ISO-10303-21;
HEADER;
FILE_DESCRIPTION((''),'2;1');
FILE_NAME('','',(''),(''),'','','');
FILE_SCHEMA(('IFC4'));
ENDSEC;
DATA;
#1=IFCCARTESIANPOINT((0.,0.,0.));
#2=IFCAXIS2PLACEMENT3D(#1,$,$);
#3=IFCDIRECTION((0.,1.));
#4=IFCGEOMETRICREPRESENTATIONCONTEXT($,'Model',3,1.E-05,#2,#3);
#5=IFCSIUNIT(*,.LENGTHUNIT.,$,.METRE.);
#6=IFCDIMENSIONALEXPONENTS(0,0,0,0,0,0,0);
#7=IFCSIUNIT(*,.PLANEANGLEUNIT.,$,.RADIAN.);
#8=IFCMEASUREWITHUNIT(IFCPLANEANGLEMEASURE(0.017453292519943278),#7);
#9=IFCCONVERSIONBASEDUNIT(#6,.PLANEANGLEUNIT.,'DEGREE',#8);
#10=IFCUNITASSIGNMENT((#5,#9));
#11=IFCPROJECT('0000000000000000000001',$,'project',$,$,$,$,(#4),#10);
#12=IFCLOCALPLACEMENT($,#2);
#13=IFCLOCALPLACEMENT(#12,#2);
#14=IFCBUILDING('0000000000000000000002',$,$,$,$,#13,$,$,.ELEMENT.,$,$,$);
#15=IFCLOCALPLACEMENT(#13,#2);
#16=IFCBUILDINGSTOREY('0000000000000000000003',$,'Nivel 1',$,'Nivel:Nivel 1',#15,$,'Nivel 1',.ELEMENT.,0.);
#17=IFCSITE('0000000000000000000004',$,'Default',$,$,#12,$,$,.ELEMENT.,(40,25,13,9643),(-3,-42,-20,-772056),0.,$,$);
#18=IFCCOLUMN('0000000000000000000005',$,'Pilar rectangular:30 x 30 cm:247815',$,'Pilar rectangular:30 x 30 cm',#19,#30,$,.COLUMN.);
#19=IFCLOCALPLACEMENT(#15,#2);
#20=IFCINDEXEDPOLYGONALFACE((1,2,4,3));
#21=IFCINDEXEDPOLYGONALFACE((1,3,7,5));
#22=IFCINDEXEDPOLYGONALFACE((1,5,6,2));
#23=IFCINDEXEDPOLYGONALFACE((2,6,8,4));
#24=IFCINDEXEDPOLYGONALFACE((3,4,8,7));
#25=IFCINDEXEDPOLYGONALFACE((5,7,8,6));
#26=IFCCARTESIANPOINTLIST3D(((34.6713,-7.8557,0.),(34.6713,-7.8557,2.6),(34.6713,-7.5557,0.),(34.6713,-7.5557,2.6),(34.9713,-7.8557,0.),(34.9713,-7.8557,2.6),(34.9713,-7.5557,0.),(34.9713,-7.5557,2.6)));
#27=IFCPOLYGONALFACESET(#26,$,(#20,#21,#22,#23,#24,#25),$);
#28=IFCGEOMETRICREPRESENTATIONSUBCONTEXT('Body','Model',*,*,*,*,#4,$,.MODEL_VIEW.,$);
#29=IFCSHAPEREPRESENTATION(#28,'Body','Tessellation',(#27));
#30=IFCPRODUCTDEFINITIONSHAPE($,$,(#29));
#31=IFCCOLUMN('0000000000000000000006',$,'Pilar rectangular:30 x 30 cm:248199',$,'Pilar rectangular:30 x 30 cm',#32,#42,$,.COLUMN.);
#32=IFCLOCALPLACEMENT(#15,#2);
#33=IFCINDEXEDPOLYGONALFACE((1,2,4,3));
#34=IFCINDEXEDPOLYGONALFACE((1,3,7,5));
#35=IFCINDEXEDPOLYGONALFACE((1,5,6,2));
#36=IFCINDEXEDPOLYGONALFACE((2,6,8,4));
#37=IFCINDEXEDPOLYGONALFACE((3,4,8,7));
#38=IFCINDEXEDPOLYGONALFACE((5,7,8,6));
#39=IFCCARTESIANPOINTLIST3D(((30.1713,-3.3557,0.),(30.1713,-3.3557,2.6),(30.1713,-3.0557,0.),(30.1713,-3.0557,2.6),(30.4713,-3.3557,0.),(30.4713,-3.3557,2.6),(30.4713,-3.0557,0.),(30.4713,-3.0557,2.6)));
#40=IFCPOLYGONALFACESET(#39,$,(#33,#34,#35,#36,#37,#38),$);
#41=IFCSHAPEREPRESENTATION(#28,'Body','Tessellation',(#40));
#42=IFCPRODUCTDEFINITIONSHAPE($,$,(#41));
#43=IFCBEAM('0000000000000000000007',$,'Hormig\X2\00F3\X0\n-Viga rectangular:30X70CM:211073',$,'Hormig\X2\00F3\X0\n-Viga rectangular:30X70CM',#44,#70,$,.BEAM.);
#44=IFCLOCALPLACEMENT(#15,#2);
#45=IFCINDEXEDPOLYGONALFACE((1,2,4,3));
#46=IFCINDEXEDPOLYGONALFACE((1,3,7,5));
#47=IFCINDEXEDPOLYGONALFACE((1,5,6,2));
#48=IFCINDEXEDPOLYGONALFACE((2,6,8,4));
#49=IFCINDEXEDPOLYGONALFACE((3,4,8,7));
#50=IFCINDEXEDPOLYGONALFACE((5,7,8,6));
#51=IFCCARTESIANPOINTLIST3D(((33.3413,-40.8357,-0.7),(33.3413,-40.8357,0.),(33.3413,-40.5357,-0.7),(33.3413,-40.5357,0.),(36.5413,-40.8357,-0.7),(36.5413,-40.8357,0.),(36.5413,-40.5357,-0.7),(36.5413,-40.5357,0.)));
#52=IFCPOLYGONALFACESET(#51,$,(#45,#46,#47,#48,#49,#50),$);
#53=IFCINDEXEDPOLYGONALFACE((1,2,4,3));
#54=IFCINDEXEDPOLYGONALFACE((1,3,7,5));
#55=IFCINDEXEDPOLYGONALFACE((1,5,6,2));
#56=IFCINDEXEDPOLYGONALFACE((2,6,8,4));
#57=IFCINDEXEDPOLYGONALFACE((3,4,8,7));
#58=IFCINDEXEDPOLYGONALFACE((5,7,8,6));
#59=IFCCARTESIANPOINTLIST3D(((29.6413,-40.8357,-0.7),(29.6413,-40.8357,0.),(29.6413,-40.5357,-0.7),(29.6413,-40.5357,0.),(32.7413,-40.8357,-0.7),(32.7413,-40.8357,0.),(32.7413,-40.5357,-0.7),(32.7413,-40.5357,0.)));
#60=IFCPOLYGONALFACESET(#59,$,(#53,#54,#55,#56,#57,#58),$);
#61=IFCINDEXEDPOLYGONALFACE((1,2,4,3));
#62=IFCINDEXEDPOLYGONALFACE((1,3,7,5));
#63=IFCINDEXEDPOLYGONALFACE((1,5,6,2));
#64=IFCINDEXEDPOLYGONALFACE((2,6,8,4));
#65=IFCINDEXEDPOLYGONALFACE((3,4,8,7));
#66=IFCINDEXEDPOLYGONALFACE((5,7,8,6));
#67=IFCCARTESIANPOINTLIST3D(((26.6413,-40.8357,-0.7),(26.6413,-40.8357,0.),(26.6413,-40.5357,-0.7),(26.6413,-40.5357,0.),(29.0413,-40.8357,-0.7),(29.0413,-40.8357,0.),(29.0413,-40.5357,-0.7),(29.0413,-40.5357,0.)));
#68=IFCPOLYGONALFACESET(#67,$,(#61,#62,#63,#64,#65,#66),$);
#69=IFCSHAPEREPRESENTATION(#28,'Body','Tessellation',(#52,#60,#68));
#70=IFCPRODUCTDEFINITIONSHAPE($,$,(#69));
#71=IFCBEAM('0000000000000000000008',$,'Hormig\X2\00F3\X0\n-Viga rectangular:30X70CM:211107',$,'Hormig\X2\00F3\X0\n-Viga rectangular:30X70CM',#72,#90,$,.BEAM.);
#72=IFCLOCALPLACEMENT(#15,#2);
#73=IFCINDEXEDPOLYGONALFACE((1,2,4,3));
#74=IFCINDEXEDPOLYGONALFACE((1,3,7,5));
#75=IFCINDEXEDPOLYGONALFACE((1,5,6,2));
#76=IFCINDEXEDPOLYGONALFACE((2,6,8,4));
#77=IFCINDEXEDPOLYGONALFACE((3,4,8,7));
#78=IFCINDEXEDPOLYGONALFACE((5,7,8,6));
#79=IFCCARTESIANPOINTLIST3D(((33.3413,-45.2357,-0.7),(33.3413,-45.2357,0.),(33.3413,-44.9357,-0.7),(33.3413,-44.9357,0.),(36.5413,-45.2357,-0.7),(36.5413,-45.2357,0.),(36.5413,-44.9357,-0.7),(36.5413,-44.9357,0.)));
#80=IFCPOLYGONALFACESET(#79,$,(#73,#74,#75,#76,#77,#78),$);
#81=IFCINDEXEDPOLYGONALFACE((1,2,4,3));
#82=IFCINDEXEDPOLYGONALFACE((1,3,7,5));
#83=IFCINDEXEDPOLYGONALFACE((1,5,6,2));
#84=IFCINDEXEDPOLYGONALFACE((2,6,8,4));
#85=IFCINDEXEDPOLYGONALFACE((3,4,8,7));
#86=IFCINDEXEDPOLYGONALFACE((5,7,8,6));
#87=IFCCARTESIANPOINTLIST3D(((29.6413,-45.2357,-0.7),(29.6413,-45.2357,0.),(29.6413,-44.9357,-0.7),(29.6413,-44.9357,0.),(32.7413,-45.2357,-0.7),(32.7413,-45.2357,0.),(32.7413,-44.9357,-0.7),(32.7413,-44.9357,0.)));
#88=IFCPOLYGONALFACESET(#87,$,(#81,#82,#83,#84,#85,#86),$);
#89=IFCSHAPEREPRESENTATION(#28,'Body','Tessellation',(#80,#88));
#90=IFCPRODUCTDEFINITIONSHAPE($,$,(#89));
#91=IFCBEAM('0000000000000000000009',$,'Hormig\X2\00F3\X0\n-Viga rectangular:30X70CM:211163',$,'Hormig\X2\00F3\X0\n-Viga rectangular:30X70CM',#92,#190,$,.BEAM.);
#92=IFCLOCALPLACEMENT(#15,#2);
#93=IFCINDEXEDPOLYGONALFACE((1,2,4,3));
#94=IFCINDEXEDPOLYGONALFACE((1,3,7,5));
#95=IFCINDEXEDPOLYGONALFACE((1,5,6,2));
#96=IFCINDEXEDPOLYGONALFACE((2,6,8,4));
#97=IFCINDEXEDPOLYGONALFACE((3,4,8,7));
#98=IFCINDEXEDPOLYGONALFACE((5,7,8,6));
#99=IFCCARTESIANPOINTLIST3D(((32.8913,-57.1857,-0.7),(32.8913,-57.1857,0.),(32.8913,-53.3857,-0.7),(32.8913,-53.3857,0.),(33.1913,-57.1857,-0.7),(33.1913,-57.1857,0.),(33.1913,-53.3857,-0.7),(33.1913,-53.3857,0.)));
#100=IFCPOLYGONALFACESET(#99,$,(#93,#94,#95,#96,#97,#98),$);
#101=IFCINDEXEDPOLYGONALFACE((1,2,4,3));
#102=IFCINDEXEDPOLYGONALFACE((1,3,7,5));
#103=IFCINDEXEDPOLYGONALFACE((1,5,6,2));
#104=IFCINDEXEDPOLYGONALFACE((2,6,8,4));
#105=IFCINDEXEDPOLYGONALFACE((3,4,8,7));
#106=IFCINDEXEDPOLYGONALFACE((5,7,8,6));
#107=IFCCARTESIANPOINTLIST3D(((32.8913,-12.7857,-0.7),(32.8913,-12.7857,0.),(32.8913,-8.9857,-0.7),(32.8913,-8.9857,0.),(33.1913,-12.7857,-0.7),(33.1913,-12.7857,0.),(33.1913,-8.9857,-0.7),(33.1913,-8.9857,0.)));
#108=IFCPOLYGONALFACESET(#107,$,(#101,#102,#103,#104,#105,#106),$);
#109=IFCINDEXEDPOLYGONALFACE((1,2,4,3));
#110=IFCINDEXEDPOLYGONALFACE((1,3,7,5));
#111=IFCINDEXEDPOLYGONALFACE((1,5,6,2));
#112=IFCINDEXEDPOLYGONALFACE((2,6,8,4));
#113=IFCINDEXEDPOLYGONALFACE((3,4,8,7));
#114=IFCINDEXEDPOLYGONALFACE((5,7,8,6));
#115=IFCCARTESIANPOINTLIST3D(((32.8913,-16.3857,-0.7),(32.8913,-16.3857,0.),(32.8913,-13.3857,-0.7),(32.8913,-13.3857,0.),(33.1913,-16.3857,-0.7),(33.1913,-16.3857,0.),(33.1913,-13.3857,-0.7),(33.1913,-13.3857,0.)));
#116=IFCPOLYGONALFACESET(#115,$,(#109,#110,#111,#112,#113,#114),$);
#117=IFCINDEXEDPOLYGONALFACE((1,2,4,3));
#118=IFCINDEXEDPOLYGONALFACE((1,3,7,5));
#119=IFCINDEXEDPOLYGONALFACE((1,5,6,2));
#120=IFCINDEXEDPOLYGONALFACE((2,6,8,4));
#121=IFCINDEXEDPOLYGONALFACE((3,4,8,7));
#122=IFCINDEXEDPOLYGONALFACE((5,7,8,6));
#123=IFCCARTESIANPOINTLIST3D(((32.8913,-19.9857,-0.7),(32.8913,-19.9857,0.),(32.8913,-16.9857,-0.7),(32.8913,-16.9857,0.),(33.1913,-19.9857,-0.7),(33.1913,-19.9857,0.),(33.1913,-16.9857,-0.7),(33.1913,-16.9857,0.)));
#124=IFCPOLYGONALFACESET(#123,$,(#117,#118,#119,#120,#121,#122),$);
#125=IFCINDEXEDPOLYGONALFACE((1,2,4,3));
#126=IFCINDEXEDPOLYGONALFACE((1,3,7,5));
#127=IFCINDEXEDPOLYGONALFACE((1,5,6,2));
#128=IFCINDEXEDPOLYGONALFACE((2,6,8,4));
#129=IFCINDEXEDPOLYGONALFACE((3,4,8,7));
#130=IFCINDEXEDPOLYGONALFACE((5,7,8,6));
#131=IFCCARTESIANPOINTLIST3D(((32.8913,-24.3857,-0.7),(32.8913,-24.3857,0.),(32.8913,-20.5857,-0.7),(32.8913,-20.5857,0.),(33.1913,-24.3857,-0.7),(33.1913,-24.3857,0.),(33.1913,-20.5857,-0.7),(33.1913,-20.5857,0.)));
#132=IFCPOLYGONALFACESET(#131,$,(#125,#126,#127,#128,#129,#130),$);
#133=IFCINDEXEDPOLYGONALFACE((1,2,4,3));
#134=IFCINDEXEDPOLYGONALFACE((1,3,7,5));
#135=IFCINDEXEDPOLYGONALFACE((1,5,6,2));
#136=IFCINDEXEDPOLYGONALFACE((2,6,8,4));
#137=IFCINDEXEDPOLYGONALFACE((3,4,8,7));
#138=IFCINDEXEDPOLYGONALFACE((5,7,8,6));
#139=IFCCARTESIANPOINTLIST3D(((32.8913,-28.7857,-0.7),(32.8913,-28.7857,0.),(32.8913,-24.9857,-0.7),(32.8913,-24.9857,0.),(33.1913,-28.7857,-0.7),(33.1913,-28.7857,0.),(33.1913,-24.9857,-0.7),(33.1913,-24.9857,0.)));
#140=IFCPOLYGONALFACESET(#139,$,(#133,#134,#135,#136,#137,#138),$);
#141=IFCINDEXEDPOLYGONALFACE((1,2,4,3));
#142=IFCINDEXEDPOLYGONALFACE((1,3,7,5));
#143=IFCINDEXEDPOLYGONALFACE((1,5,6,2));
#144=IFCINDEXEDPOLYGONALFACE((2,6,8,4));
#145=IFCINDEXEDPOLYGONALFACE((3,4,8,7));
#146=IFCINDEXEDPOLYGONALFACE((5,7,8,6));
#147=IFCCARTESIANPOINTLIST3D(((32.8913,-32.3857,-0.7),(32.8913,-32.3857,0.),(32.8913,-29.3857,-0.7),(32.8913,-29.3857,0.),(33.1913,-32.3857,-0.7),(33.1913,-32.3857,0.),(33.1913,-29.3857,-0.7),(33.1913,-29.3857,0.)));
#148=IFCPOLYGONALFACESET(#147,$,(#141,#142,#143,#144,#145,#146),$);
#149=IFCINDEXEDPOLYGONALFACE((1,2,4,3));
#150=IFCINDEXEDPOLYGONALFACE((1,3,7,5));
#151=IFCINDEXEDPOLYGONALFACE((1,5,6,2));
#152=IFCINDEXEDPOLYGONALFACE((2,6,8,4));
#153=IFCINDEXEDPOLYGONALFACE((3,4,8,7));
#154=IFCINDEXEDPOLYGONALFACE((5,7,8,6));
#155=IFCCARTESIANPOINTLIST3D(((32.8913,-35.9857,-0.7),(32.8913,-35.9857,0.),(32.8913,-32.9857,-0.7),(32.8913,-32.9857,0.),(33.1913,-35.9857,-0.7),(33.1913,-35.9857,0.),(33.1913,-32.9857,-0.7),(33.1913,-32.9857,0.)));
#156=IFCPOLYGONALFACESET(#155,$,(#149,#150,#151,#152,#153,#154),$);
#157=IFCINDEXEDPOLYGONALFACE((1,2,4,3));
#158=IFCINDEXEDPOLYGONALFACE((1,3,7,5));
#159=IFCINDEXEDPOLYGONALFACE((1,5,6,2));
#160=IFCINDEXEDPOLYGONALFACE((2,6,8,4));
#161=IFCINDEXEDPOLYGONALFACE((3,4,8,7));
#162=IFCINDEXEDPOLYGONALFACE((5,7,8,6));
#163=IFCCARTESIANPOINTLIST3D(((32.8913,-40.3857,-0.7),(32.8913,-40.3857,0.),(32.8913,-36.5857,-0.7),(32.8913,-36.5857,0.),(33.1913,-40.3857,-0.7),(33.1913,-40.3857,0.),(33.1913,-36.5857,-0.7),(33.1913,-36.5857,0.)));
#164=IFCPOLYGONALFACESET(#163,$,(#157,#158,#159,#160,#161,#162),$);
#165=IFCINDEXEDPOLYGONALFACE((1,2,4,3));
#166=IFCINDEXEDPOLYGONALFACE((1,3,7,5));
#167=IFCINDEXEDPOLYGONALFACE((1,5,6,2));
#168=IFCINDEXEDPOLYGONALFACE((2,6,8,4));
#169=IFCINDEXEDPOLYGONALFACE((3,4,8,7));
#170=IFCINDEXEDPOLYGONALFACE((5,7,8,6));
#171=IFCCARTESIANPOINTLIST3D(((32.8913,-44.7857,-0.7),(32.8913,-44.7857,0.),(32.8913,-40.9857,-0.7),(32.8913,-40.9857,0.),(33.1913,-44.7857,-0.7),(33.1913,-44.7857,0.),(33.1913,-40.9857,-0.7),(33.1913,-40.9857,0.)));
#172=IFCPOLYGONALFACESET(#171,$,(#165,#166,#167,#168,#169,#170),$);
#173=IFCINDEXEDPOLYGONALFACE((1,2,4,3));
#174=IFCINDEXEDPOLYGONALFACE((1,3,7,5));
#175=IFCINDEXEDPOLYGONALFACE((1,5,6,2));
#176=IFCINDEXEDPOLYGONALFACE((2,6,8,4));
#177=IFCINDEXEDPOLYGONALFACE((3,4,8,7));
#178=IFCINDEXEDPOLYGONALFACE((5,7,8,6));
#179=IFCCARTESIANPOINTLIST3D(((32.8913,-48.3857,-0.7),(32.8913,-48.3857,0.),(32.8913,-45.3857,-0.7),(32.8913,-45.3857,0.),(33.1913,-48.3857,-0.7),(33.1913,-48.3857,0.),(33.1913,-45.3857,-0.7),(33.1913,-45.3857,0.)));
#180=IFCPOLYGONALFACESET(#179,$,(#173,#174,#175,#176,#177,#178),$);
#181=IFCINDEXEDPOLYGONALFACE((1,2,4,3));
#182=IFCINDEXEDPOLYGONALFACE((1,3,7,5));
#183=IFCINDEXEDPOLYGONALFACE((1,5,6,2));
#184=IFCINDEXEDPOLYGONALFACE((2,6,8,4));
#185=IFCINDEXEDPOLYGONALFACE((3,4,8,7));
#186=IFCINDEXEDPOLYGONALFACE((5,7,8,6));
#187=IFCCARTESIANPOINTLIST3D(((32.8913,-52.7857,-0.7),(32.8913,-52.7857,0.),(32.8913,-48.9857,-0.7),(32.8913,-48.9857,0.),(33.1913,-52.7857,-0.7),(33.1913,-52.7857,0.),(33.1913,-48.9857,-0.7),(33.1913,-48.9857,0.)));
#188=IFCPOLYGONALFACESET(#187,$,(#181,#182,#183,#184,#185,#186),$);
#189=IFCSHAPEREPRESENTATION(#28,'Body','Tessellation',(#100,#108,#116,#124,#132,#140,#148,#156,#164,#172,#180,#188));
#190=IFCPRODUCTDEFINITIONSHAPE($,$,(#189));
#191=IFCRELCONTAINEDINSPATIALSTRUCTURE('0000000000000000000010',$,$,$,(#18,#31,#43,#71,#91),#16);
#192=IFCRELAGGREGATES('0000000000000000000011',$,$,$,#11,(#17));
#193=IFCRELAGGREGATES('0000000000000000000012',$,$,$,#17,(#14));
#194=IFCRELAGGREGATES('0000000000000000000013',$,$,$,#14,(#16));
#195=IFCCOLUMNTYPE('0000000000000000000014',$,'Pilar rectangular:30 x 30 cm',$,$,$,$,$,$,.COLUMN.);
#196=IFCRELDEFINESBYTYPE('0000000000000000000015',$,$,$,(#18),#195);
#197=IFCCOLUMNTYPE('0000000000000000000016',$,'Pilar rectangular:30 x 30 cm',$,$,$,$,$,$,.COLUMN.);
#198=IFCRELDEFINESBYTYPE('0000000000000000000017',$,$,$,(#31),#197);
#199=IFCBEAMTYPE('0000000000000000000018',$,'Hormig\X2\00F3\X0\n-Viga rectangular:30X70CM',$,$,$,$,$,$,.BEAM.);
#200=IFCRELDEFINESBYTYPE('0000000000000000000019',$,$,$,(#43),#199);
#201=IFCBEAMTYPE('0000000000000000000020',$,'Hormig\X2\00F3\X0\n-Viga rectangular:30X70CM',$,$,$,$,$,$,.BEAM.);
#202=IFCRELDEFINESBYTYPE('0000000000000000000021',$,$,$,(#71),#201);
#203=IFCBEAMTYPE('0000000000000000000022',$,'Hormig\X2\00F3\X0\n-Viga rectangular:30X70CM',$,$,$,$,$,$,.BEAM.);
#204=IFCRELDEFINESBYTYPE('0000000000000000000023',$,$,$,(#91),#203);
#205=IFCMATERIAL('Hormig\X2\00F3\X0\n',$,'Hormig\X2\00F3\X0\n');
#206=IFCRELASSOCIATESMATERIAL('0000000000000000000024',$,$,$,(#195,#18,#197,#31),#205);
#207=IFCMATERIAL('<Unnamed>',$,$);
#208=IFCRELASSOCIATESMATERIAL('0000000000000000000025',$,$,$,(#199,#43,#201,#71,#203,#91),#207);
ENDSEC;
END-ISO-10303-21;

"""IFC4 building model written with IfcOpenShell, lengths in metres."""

from ifc_helpers import new_model, entity, si_unit, converted_unit, direction, frame, origin, place, context, subcontext, project, spatial, indexed_curve, outline, extrude, source, transform, mapped, material, type_object, type_shapes, element, save


model = new_model("IFC4")

# Units and contexts
model_context = context("Model", 3, precision=1e-05, world=origin(), true_north=direction((0.0, 1.0)))
body_context = subcontext(model_context, "Body", "Model", "MODEL_VIEW")
ifc_project = project(units=[si_unit("LENGTHUNIT", "METRE"), converted_unit("PLANEANGLEUNIT", "DEGREE", entity("IfcPlaneAngleMeasure", 0.017453292519943278), si_unit("PLANEANGLEUNIT", "RADIAN"), dimensions=[0, 0, 0, 0, 0, 0, 0])], contexts=[model_context])

# Site, building, storey
site_placement = place(None, origin())
site = spatial("IfcSite", under=ifc_project, at=site_placement, Name="Default", CompositionType="ELEMENT", RefLatitude=(40, 25, 13, 9643), RefLongitude=(-3, -42, -20, -772056), RefElevation=0.0)
building_placement = place(site_placement, origin())
building = spatial("IfcBuilding", under=site, at=building_placement, CompositionType="ELEMENT")
storey_placement = place(building_placement, origin())
storey = spatial("IfcBuildingStorey", under=building, at=storey_placement, Name="Nivel 1", ObjectType="Nivel:Nivel 1", LongName="Nivel 1", CompositionType="ELEMENT", Elevation=0.0)

# Columns
ifc_material_1 = material(Name="Hormigón", Category="Hormigón")
column_type_1 = type_object("IfcColumnType", Name="Pilar rectangular:30 x 30 cm", PredefinedType="COLUMN", material=ifc_material_1)
shared_shape_1 = source(origin(), body_context, "Body", "SweptSolid", [
    extrude(outline(indexed_curve([(-0.15, -0.15), (0.15, -0.15), (0.15, 0.15), (-0.15, 0.15), (-0.15, -0.15)], self_intersect=False)), frame((34.8213, -7.7057, 0.0), z_axis=(0.0, 0.0, 1.0), x_axis=(-1.0, 0.0, 0.0)), (0.0, 0.0, 1.0), 2.6),
])
type_shapes(column_type_1, [shared_shape_1])
column_1_placement = place(storey_placement, origin())
element("IfcColumn", 1, at=column_1_placement, inside=storey, type_object=column_type_1, material=ifc_material_1, Name="Pilar rectangular:30 x 30 cm:247815", ObjectType="Pilar rectangular:30 x 30 cm", PredefinedType="COLUMN", context=body_context, shape_type="MappedRepresentation", body=[
    mapped(shared_shape_1, transform((0.0, 0.0, 0.0), scale=1.0)),
])
column_type_2 = type_object("IfcColumnType", Name="Pilar rectangular:30 x 30 cm", PredefinedType="COLUMN", material=ifc_material_1)
shared_shape_2 = source(origin(), body_context, "Body", "SweptSolid", [
    extrude(outline(indexed_curve([(-0.15, -0.15), (0.15, -0.15), (0.15, 0.15), (-0.15, 0.15), (-0.15, -0.15)], self_intersect=False)), frame((30.3213, -3.2057, 0.0), z_axis=(0.0, 0.0, 1.0), x_axis=(-1.0, 0.0, 0.0)), (0.0, 0.0, 1.0), 2.6),
])
type_shapes(column_type_2, [shared_shape_2])
column_2_placement = place(storey_placement, origin())
element("IfcColumn", 2, at=column_2_placement, inside=storey, type_object=column_type_2, material=ifc_material_1, Name="Pilar rectangular:30 x 30 cm:248199", ObjectType="Pilar rectangular:30 x 30 cm", PredefinedType="COLUMN", context=body_context, shape_type="MappedRepresentation", body=[
    mapped(shared_shape_2, transform((0.0, 0.0, 0.0), scale=1.0)),
])

# Beams
ifc_material_2 = material(Name="<Unnamed>")
beam_type_1 = type_object("IfcBeamType", Name="Hormigón-Viga rectangular:30X70CM", PredefinedType="BEAM", material=ifc_material_2)
shared_shape_3 = source(origin(), body_context, "Body", "SweptSolid", [
    extrude(outline(indexed_curve([(-0.35, -0.15), (0.35, -0.15), (0.35, 0.15), (-0.35, 0.15), (-0.35, -0.15)], self_intersect=False)), frame((36.5413, -40.6857, -0.35), z_axis=(-1.0, 0.0, 0.0), x_axis=(0.0, 0.0, -1.0)), (0.0, 0.0, 1.0), 3.2),
    extrude(outline(indexed_curve([(-0.35, -0.15), (0.35, -0.15), (0.35, 0.15), (-0.35, 0.15), (-0.35, -0.15)], self_intersect=False)), frame((32.7413, -40.6857, -0.35), z_axis=(-1.0, 0.0, 0.0), x_axis=(0.0, 0.0, -1.0)), (0.0, 0.0, 1.0), 3.1),
    extrude(outline(indexed_curve([(-0.35, -0.15), (0.35, -0.15), (0.35, 0.15), (-0.35, 0.15), (-0.35, -0.15)], self_intersect=False)), frame((29.0413, -40.6857, -0.35), z_axis=(-1.0, 0.0, 0.0), x_axis=(0.0, 0.0, -1.0)), (0.0, 0.0, 1.0), 2.4),
])
type_shapes(beam_type_1, [shared_shape_3])
beam_1_placement = place(storey_placement, origin())
element("IfcBeam", 3, at=beam_1_placement, inside=storey, type_object=beam_type_1, material=ifc_material_2, Name="Hormigón-Viga rectangular:30X70CM:211073", ObjectType="Hormigón-Viga rectangular:30X70CM", PredefinedType="BEAM", context=body_context, shape_type="MappedRepresentation", body=[
    mapped(shared_shape_3, transform((0.0, 0.0, 0.0), scale=1.0)),
])
beam_type_2 = type_object("IfcBeamType", Name="Hormigón-Viga rectangular:30X70CM", PredefinedType="BEAM", material=ifc_material_2)
shared_shape_4 = source(origin(), body_context, "Body", "SweptSolid", [
    extrude(outline(indexed_curve([(-0.35, -0.15), (0.35, -0.15), (0.35, 0.15), (-0.35, 0.15), (-0.35, -0.15)], self_intersect=False)), frame((36.5413, -45.0857, -0.35), z_axis=(-1.0, 0.0, 0.0), x_axis=(0.0, 0.0, -1.0)), (0.0, 0.0, 1.0), 3.2),
    extrude(outline(indexed_curve([(-0.35, -0.15), (0.35, -0.15), (0.35, 0.15), (-0.35, 0.15), (-0.35, -0.15)], self_intersect=False)), frame((32.7413, -45.0857, -0.35), z_axis=(-1.0, 0.0, 0.0), x_axis=(0.0, 0.0, -1.0)), (0.0, 0.0, 1.0), 3.1),
])
type_shapes(beam_type_2, [shared_shape_4])
beam_2_placement = place(storey_placement, origin())
element("IfcBeam", 4, at=beam_2_placement, inside=storey, type_object=beam_type_2, material=ifc_material_2, Name="Hormigón-Viga rectangular:30X70CM:211107", ObjectType="Hormigón-Viga rectangular:30X70CM", PredefinedType="BEAM", context=body_context, shape_type="MappedRepresentation", body=[
    mapped(shared_shape_4, transform((0.0, 0.0, 0.0), scale=1.0)),
])
beam_type_3 = type_object("IfcBeamType", Name="Hormigón-Viga rectangular:30X70CM", PredefinedType="BEAM", material=ifc_material_2)
shared_shape_5 = source(origin(), body_context, "Body", "SweptSolid", [
    extrude(outline(indexed_curve([(-0.15, -0.35), (0.15, -0.35), (0.15, 0.35), (-0.15, 0.35), (-0.15, -0.35)], self_intersect=False)), frame((33.0413, -57.1857, -0.35), z_axis=(0.0, 1.0, 0.0), x_axis=(-1.0, 0.0, 0.0)), (0.0, 0.0, 1.0), 3.8),
    extrude(outline(indexed_curve([(-0.15, -0.35), (0.15, -0.35), (0.15, 0.35), (-0.15, 0.35), (-0.15, -0.35)], self_intersect=False)), frame((33.0413, -12.7857, -0.35), z_axis=(0.0, 1.0, 0.0), x_axis=(-1.0, 0.0, 0.0)), (0.0, 0.0, 1.0), 3.8),
    extrude(outline(indexed_curve([(-0.15, -0.35), (0.15, -0.35), (0.15, 0.35), (-0.15, 0.35), (-0.15, -0.35)], self_intersect=False)), frame((33.0413, -16.3857, -0.35), z_axis=(0.0, 1.0, 0.0), x_axis=(-1.0, 0.0, 0.0)), (0.0, 0.0, 1.0), 3.0),
    extrude(outline(indexed_curve([(-0.15, -0.35), (0.15, -0.35), (0.15, 0.35), (-0.15, 0.35), (-0.15, -0.35)], self_intersect=False)), frame((33.0413, -19.9857, -0.35), z_axis=(0.0, 1.0, 0.0), x_axis=(-1.0, 0.0, 0.0)), (0.0, 0.0, 1.0), 3.0),
    extrude(outline(indexed_curve([(-0.15, -0.35), (0.15, -0.35), (0.15, 0.35), (-0.15, 0.35), (-0.15, -0.35)], self_intersect=False)), frame((33.0413, -24.3857, -0.35), z_axis=(0.0, 1.0, 0.0), x_axis=(-1.0, 0.0, 0.0)), (0.0, 0.0, 1.0), 3.8),
    extrude(outline(indexed_curve([(-0.15, -0.35), (0.15, -0.35), (0.15, 0.35), (-0.15, 0.35), (-0.15, -0.35)], self_intersect=False)), frame((33.0413, -28.7857, -0.35), z_axis=(0.0, 1.0, 0.0), x_axis=(-1.0, 0.0, 0.0)), (0.0, 0.0, 1.0), 3.8),
    extrude(outline(indexed_curve([(-0.15, -0.35), (0.15, -0.35), (0.15, 0.35), (-0.15, 0.35), (-0.15, -0.35)], self_intersect=False)), frame((33.0413, -32.3857, -0.35), z_axis=(0.0, 1.0, 0.0), x_axis=(-1.0, 0.0, 0.0)), (0.0, 0.0, 1.0), 3.0),
    extrude(outline(indexed_curve([(-0.15, -0.35), (0.15, -0.35), (0.15, 0.35), (-0.15, 0.35), (-0.15, -0.35)], self_intersect=False)), frame((33.0413, -35.9857, -0.35), z_axis=(0.0, 1.0, 0.0), x_axis=(-1.0, 0.0, 0.0)), (0.0, 0.0, 1.0), 3.0),
    extrude(outline(indexed_curve([(-0.15, -0.35), (0.15, -0.35), (0.15, 0.35), (-0.15, 0.35), (-0.15, -0.35)], self_intersect=False)), frame((33.0413, -40.3857, -0.35), z_axis=(0.0, 1.0, 0.0), x_axis=(-1.0, 0.0, 0.0)), (0.0, 0.0, 1.0), 3.8),
    extrude(outline(indexed_curve([(-0.15, -0.35), (0.15, -0.35), (0.15, 0.35), (-0.15, 0.35), (-0.15, -0.35)], self_intersect=False)), frame((33.0413, -44.7857, -0.35), z_axis=(0.0, 1.0, 0.0), x_axis=(-1.0, 0.0, 0.0)), (0.0, 0.0, 1.0), 3.8),
    extrude(outline(indexed_curve([(-0.15, -0.35), (0.15, -0.35), (0.15, 0.35), (-0.15, 0.35), (-0.15, -0.35)], self_intersect=False)), frame((33.0413, -48.3857, -0.35), z_axis=(0.0, 1.0, 0.0), x_axis=(-1.0, 0.0, 0.0)), (0.0, 0.0, 1.0), 3.0),
    extrude(outline(indexed_curve([(-0.15, -0.35), (0.15, -0.35), (0.15, 0.35), (-0.15, 0.35), (-0.15, -0.35)], self_intersect=False)), frame((33.0413, -52.7857, -0.35), z_axis=(0.0, 1.0, 0.0), x_axis=(-1.0, 0.0, 0.0)), (0.0, 0.0, 1.0), 3.8),
])
type_shapes(beam_type_3, [shared_shape_5])
beam_3_placement = place(storey_placement, origin())
element("IfcBeam", 5, at=beam_3_placement, inside=storey, type_object=beam_type_3, material=ifc_material_2, Name="Hormigón-Viga rectangular:30X70CM:211163", ObjectType="Hormigón-Viga rectangular:30X70CM", PredefinedType="BEAM", context=body_context, shape_type="MappedRepresentation", body=[
    mapped(shared_shape_5, transform((0.0, 0.0, 0.0), scale=1.0)),
])

save(model, "model.ifc")
